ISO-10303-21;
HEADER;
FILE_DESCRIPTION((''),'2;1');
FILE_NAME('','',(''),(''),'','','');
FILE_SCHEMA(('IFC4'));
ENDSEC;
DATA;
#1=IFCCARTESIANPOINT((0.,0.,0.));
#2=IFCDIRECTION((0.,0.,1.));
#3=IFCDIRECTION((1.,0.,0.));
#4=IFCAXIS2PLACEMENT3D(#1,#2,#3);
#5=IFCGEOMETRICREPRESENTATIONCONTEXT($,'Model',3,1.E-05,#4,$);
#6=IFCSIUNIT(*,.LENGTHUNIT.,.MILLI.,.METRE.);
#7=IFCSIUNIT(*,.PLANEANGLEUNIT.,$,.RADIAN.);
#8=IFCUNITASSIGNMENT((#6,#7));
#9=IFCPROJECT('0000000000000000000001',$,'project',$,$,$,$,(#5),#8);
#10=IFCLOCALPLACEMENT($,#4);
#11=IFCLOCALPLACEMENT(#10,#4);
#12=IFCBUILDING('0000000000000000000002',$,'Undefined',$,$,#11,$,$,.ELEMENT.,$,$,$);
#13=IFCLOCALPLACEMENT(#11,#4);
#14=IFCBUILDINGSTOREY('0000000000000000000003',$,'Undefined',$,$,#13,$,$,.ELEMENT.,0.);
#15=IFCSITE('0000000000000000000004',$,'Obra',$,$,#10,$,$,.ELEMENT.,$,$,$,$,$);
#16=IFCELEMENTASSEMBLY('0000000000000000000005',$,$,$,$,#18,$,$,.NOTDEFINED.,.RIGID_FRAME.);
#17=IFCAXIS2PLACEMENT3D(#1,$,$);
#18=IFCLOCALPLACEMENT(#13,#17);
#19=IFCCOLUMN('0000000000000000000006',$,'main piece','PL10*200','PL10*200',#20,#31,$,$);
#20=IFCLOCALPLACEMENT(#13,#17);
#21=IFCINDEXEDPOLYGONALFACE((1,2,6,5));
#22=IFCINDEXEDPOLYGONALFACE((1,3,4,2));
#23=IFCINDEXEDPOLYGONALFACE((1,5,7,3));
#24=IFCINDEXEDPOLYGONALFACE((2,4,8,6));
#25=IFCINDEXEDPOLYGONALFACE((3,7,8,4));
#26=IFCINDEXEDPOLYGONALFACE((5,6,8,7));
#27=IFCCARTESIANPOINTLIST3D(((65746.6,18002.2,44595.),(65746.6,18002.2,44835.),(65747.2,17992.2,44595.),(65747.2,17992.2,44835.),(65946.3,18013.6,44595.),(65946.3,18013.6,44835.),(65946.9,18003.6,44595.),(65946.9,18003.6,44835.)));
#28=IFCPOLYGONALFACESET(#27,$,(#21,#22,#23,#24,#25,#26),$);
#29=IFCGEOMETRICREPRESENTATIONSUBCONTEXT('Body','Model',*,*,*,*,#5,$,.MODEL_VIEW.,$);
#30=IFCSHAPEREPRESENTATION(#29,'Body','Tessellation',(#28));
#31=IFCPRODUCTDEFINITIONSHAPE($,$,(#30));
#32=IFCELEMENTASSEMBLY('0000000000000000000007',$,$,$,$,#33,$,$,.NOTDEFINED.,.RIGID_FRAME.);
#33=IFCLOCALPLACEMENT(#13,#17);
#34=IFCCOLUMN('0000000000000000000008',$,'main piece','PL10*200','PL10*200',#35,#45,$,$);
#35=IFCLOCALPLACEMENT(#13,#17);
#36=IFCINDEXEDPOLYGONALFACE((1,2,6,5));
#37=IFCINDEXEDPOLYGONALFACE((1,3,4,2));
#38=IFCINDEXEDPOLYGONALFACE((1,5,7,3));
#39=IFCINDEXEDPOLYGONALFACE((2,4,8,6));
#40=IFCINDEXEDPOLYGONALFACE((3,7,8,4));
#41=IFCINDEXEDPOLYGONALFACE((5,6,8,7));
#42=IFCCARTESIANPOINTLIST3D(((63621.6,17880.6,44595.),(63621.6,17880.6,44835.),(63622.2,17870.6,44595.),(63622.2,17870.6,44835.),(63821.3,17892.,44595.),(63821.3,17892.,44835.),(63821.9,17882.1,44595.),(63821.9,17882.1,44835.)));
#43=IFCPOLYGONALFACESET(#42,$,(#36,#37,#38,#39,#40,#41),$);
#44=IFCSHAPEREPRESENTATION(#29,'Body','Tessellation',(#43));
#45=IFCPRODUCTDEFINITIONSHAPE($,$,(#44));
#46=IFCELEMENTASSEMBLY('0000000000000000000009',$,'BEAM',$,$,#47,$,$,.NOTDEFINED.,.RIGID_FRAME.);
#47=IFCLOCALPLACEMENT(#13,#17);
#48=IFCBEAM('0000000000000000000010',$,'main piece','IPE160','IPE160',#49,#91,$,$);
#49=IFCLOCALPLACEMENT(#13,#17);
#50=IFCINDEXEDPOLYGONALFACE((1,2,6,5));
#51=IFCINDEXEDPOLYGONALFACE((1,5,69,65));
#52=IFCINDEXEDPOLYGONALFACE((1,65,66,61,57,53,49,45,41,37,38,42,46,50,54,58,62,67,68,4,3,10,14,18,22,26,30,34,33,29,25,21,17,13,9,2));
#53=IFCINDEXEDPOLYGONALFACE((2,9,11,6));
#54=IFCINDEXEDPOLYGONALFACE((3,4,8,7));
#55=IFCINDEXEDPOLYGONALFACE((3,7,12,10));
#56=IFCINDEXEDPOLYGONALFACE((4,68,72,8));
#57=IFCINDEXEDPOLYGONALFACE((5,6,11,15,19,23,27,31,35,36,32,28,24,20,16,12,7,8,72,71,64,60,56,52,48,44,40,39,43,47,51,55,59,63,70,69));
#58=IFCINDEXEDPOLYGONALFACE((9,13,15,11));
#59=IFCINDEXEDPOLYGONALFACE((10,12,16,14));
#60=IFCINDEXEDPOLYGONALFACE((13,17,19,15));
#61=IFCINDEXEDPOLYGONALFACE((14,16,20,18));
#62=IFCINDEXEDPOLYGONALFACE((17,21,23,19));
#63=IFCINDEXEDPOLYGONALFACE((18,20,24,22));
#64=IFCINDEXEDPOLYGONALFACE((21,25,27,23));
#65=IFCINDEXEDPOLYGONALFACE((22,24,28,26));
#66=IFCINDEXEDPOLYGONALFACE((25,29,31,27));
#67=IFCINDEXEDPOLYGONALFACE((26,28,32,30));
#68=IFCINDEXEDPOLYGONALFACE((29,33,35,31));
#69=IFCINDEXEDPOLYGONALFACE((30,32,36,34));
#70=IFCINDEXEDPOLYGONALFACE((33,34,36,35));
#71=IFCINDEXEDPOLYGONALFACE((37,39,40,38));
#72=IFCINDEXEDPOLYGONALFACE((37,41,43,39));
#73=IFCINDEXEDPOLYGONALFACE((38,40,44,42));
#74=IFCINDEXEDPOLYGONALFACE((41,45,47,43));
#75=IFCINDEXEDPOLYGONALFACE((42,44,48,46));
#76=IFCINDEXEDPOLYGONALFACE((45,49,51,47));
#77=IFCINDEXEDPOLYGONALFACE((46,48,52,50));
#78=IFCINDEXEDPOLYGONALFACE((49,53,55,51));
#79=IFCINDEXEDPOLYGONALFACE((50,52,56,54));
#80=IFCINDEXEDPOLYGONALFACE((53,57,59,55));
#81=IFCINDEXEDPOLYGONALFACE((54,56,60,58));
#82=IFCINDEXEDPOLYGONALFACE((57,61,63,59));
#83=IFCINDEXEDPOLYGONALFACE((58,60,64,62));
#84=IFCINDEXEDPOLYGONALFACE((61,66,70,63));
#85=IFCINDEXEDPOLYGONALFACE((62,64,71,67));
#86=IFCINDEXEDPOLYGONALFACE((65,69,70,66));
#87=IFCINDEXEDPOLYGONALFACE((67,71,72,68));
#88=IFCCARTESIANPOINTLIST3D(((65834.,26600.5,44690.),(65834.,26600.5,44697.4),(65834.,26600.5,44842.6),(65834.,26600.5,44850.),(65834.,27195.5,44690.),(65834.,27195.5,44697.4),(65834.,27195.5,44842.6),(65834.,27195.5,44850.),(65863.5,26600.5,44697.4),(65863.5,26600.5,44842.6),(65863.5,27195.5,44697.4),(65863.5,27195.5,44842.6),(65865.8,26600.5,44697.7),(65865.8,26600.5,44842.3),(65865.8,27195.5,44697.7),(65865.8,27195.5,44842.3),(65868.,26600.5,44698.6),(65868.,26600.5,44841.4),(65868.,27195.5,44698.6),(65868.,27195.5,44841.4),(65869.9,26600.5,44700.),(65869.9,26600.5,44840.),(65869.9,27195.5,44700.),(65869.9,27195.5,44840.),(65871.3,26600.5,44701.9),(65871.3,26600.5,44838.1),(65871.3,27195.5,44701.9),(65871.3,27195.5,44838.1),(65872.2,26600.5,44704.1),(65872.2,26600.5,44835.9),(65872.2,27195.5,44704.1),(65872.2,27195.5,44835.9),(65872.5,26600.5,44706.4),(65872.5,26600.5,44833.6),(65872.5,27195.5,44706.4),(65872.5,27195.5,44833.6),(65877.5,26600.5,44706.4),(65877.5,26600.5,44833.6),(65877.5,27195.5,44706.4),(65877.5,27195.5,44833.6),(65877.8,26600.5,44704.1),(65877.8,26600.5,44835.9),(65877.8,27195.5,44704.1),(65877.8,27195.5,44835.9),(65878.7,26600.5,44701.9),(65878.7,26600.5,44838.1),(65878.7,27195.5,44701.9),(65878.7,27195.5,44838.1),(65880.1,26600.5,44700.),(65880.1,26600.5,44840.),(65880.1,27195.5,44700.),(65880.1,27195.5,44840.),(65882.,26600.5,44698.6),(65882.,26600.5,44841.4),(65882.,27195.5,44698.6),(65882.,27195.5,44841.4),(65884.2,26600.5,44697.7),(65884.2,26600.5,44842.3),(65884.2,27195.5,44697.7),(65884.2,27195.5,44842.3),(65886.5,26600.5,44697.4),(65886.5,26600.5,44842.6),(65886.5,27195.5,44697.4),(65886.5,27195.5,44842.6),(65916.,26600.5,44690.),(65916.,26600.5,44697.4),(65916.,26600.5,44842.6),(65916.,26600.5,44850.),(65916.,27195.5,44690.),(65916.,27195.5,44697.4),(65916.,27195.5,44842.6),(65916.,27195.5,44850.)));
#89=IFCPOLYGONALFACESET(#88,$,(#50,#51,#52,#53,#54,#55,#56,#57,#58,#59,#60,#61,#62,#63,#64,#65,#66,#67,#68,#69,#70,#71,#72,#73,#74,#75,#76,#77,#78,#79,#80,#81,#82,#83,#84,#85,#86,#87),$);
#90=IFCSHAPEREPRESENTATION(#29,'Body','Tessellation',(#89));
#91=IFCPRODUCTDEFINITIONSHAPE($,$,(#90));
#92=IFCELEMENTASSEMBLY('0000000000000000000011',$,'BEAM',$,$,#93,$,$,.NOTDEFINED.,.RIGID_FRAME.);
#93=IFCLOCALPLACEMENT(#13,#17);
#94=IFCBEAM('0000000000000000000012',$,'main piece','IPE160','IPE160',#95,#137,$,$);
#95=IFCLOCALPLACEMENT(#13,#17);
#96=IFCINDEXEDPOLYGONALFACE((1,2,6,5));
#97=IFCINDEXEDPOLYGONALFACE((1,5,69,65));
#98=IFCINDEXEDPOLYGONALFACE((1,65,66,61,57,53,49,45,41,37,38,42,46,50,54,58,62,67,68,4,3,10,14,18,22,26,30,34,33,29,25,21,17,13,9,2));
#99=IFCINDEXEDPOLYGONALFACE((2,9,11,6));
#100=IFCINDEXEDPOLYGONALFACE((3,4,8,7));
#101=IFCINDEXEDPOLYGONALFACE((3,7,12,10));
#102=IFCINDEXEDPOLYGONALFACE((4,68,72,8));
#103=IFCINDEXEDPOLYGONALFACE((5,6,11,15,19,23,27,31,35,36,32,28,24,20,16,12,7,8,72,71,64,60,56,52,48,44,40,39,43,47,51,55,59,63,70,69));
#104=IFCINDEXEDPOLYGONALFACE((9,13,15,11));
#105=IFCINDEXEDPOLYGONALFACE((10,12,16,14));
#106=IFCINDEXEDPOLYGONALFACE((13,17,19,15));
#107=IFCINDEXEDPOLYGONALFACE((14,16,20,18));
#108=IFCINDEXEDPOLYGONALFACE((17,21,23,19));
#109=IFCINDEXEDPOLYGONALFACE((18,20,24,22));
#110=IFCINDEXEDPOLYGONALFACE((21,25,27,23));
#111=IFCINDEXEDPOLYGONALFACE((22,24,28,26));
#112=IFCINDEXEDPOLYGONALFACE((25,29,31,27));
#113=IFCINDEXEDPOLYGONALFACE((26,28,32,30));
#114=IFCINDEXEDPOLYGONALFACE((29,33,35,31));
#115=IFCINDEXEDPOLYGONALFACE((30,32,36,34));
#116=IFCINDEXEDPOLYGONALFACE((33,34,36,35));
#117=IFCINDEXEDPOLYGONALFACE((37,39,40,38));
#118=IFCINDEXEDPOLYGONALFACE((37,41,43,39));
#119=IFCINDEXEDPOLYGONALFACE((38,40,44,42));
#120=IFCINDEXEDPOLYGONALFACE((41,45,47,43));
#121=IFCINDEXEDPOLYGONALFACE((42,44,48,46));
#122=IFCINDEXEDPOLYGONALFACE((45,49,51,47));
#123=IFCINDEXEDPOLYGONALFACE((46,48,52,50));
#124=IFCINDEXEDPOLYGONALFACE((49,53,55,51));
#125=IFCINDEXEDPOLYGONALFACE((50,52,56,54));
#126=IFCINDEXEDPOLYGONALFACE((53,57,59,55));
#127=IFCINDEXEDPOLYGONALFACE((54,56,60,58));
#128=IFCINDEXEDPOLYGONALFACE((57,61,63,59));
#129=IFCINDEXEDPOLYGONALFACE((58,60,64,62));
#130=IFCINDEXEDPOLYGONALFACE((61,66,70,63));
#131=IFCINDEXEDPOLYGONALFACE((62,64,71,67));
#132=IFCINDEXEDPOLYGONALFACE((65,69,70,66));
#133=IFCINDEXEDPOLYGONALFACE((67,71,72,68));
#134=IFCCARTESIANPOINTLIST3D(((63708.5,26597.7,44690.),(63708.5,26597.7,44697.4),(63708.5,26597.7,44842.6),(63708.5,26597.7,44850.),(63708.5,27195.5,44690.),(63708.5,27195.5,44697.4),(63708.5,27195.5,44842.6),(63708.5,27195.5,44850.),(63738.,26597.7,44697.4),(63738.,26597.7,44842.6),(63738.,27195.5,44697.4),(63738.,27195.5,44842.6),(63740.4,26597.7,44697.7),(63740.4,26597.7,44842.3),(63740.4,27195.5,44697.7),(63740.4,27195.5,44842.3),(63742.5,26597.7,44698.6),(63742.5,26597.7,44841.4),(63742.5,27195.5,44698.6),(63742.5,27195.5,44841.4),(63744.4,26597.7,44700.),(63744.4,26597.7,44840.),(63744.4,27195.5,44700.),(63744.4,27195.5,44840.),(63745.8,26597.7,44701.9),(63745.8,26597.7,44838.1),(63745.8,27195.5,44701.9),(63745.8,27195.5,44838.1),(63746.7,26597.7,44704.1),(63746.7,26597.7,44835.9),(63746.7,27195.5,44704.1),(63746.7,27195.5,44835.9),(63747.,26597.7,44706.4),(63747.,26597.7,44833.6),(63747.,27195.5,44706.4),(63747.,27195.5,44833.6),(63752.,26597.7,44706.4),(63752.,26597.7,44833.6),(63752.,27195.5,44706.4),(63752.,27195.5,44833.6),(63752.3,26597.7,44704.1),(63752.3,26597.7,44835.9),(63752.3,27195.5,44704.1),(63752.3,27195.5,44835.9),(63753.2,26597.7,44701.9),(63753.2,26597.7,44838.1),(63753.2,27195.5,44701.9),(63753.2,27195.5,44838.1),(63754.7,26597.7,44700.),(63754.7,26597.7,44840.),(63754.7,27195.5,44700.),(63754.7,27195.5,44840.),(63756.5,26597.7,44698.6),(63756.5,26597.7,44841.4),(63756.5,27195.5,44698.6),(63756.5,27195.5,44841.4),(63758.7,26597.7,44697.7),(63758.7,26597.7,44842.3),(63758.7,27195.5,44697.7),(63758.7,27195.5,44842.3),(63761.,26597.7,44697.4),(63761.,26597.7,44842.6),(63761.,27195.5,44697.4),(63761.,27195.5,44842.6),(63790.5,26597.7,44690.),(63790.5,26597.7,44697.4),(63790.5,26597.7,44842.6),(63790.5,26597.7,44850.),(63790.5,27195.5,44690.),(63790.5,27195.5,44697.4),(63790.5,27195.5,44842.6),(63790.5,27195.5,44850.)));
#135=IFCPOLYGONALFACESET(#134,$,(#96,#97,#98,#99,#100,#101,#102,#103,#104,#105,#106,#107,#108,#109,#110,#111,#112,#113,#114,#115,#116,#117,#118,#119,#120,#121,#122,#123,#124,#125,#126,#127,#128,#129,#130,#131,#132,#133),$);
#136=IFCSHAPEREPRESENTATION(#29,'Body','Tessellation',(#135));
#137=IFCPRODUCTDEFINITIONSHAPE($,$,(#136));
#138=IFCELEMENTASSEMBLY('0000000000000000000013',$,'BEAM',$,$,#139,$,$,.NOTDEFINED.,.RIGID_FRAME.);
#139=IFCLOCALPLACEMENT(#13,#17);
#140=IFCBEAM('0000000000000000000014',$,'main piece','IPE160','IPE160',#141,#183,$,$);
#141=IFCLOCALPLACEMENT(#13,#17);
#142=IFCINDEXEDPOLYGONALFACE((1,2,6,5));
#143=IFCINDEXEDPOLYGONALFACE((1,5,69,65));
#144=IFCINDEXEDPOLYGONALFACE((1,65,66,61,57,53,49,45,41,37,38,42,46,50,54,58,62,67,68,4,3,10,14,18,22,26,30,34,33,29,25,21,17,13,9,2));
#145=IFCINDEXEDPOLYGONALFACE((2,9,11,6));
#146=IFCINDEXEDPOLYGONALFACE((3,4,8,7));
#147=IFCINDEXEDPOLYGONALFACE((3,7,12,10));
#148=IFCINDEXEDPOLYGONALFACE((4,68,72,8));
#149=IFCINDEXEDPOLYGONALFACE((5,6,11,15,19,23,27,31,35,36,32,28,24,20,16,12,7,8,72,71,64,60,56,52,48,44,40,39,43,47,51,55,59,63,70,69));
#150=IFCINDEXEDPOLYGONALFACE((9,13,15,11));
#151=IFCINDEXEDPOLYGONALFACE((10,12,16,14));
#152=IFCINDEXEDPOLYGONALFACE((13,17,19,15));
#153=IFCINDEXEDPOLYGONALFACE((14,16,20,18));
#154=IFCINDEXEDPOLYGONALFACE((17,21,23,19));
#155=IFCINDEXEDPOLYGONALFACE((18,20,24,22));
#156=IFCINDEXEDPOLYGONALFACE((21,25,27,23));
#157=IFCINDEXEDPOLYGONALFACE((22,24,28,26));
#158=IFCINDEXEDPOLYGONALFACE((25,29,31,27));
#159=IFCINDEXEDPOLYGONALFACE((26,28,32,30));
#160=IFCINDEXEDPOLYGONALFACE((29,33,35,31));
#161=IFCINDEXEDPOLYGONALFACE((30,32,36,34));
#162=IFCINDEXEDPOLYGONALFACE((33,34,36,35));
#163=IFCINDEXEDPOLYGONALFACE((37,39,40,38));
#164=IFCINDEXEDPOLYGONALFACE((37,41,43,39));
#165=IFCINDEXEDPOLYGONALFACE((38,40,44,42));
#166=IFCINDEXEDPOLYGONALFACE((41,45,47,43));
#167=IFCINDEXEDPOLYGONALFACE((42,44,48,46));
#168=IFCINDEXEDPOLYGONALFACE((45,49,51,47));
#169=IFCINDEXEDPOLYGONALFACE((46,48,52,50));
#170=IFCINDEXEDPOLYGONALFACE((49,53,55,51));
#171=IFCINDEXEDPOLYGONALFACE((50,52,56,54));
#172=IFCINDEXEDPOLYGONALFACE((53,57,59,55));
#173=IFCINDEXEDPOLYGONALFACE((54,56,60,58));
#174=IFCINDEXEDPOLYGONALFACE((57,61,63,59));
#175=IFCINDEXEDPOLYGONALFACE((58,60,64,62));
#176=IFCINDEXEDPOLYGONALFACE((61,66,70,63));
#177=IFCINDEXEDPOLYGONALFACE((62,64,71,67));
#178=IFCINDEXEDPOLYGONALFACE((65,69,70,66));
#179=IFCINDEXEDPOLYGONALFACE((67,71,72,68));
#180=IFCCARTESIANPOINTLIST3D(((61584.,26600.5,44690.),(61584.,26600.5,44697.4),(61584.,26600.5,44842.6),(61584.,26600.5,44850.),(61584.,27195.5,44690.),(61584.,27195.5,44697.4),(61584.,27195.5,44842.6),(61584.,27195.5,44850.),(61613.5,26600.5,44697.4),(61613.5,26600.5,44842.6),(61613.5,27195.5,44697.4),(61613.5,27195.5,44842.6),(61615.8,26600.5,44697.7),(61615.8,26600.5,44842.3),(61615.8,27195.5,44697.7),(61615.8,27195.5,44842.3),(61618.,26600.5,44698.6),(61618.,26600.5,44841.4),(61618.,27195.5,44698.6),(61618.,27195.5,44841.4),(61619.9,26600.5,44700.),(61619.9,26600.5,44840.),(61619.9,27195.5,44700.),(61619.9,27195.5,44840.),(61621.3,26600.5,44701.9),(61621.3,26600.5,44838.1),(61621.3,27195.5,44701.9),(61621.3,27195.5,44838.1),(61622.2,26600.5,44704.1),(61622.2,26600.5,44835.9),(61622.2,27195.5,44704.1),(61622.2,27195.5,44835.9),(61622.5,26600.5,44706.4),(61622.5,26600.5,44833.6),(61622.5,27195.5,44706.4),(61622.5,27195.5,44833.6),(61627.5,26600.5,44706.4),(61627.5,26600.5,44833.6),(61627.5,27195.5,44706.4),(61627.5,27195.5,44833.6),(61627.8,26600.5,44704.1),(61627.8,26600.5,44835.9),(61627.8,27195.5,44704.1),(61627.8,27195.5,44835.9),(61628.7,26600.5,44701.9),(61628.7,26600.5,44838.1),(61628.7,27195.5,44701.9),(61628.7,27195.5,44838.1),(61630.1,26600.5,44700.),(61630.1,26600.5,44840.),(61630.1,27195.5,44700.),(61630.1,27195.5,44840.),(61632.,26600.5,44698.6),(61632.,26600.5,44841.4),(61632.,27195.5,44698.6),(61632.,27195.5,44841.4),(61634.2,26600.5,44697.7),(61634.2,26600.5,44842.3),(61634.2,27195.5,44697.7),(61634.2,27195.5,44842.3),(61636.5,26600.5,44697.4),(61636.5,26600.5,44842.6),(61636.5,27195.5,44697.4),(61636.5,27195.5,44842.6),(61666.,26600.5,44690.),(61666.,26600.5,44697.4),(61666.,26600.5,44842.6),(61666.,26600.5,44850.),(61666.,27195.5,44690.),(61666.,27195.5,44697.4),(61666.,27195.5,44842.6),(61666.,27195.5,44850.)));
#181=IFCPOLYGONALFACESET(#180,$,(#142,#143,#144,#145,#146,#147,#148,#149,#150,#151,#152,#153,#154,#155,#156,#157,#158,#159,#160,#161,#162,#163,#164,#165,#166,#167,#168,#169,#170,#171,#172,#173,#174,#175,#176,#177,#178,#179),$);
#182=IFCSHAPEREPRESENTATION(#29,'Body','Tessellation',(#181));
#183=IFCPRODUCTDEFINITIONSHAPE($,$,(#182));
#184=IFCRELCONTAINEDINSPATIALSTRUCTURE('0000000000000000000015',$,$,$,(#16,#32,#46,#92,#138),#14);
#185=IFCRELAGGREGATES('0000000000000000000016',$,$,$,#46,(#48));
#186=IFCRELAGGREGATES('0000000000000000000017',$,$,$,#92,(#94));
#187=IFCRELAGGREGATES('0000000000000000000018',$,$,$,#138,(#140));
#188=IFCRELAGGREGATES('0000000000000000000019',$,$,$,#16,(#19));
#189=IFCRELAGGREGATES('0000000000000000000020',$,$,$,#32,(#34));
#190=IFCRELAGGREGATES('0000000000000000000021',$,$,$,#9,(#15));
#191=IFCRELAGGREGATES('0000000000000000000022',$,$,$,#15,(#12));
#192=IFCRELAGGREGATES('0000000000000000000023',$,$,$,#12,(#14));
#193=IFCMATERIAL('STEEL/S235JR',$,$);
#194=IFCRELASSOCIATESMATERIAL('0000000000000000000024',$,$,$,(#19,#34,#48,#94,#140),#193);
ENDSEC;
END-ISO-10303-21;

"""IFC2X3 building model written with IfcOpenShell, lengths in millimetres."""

from ifc_helpers import new_model, si_unit, frame, origin_with_axes, origin_2d_with_axis, place, context, subcontext, project, spatial, rectangle, i_section, extrude, material, element, aggregate, save


model = new_model("IFC2X3")

# Units and contexts
model_context = context("Model", 3, precision=1e-05, world=origin_with_axes())
body_context = subcontext(model_context, "Body", "Model", "MODEL_VIEW")
ifc_project = project(units=[si_unit("LENGTHUNIT", "METRE", prefix="MILLI"), si_unit("PLANEANGLEUNIT", "RADIAN")], contexts=[model_context])

# Site, building, storey
site_placement = place(None, origin_with_axes())
site = spatial("IfcSite", under=ifc_project, at=site_placement, Name="Obra", CompositionType="ELEMENT")
building_placement = place(site_placement, origin_with_axes())
building = spatial("IfcBuilding", under=site, at=building_placement, Name="Undefined", CompositionType="ELEMENT")
storey_placement = place(building_placement, origin_with_axes())
storey = spatial("IfcBuildingStorey", under=building, at=storey_placement, Name="Undefined", CompositionType="ELEMENT", Elevation=0.0)

# Element assemblies, columns
assembly_1_placement = place(storey_placement, origin_with_axes())
assembly_1 = element("IfcElementAssembly", 1, at=assembly_1_placement, inside=storey, AssemblyPlace="NOTDEFINED", PredefinedType="RIGID_FRAME")
ifc_material_1 = material(Name="STEEL/S235JR")
column_1_placement = place(assembly_1_placement, frame((65846.7, 18002.9, 44595.0), z_axis=(0.0, 0.0, 1.0), x_axis=(0.998368, 0.057107, 0.0)))
column_1 = element("IfcColumn", 2, at=column_1_placement, material=ifc_material_1, Name="main piece", Description="PL10*200", ObjectType="PL10*200", context=body_context, shape_type="SweptSolid", body=[
    extrude(rectangle(XDim=10.0, YDim=200.0, at=origin_2d_with_axis()), frame((0.0, 0.0, 240.0), z_axis=(0.0, 0.0, -1.0), x_axis=(0.0, 1.0, 0.0)), (0.0, 0.0, 1.0), 240.0),
])
assembly_2_placement = place(storey_placement, origin_with_axes())
assembly_2 = element("IfcElementAssembly", 3, at=assembly_2_placement, inside=storey, AssemblyPlace="NOTDEFINED", PredefinedType="RIGID_FRAME")
column_2_placement = place(assembly_2_placement, frame((63721.7, 17881.3, 44595.0), z_axis=(0.0, 0.0, 1.0), x_axis=(0.998368, 0.057107, 0.0)))
column_2 = element("IfcColumn", 4, at=column_2_placement, material=ifc_material_1, Name="main piece", Description="PL10*200", ObjectType="PL10*200", context=body_context, shape_type="SweptSolid", body=[
    extrude(rectangle(XDim=10.0, YDim=200.0, at=origin_2d_with_axis()), frame((0.0, 0.0, 240.0), z_axis=(0.0, 0.0, -1.0), x_axis=(0.0, 1.0, 0.0)), (0.0, 0.0, 1.0), 240.0),
])

# Element assemblies, beams
assembly_3_placement = place(storey_placement, origin_with_axes())
assembly_3 = element("IfcElementAssembly", 5, at=assembly_3_placement, inside=storey, Name="BEAM", AssemblyPlace="NOTDEFINED", PredefinedType="RIGID_FRAME")
beam_1_placement = place(assembly_3_placement, frame((65875.0, 26600.5, 44770.0), z_axis=(0.0, 0.0, 1.0), x_axis=(0.0, 1.0, 0.0)))
beam_1 = element("IfcBeam", 6, at=beam_1_placement, material=ifc_material_1, Name="main piece", Description="IPE160", ObjectType="IPE160", context=body_context, shape_type="SweptSolid", body=[
    extrude(i_section(OverallWidth=82.0, OverallDepth=160.0, WebThickness=5.0, FlangeThickness=7.4, FilletRadius=9.0, at=origin_2d_with_axis()), frame((595.1, 0.0, 0.0), z_axis=(-1.0, 0.0, 0.0), x_axis=(0.0, -1.0, 0.0)), (0.0, 0.0, 1.0), 595.0),
])
aggregate(assembly_3, [beam_1])
assembly_4_placement = place(storey_placement, origin_with_axes())
assembly_4 = element("IfcElementAssembly", 7, at=assembly_4_placement, inside=storey, Name="BEAM", AssemblyPlace="NOTDEFINED", PredefinedType="RIGID_FRAME")
beam_2_placement = place(assembly_4_placement, frame((63749.5, 26597.7, 44770.0), z_axis=(0.0, 0.0, 1.0), x_axis=(0.0, 1.0, 0.0)))
beam_2 = element("IfcBeam", 8, at=beam_2_placement, material=ifc_material_1, Name="main piece", Description="IPE160", ObjectType="IPE160", context=body_context, shape_type="SweptSolid", body=[
    extrude(i_section(OverallWidth=82.0, OverallDepth=160.0, WebThickness=5.0, FlangeThickness=7.4, FilletRadius=9.0, at=origin_2d_with_axis()), frame((597.8, 0.0, 0.0), z_axis=(-1.0, 0.0, 0.0), x_axis=(0.0, -1.0, 0.0)), (0.0, 0.0, 1.0), 597.8),
])
aggregate(assembly_4, [beam_2])
assembly_5_placement = place(storey_placement, origin_with_axes())
assembly_5 = element("IfcElementAssembly", 9, at=assembly_5_placement, inside=storey, Name="BEAM", AssemblyPlace="NOTDEFINED", PredefinedType="RIGID_FRAME")
beam_3_placement = place(assembly_5_placement, frame((61625.0, 27195.5, 44770.0), z_axis=(0.0, 0.0, 1.0), x_axis=(0.0, -1.0, 0.0)))
beam_3 = element("IfcBeam", 10, at=beam_3_placement, material=ifc_material_1, Name="main piece", Description="IPE160", ObjectType="IPE160", context=body_context, shape_type="SweptSolid", body=[
    extrude(i_section(OverallWidth=82.0, OverallDepth=160.0, WebThickness=5.0, FlangeThickness=7.4, FilletRadius=9.0, at=origin_2d_with_axis()), frame((595.0, 0.0, 0.0), z_axis=(-1.0, 0.0, 0.0), x_axis=(0.0, -1.0, 0.0)), (0.0, 0.0, 1.0), 595.0),
])
aggregate(assembly_5, [beam_3])

aggregate(assembly_1, [column_1])
aggregate(assembly_2, [column_2])

save(model, "model.ifc")
